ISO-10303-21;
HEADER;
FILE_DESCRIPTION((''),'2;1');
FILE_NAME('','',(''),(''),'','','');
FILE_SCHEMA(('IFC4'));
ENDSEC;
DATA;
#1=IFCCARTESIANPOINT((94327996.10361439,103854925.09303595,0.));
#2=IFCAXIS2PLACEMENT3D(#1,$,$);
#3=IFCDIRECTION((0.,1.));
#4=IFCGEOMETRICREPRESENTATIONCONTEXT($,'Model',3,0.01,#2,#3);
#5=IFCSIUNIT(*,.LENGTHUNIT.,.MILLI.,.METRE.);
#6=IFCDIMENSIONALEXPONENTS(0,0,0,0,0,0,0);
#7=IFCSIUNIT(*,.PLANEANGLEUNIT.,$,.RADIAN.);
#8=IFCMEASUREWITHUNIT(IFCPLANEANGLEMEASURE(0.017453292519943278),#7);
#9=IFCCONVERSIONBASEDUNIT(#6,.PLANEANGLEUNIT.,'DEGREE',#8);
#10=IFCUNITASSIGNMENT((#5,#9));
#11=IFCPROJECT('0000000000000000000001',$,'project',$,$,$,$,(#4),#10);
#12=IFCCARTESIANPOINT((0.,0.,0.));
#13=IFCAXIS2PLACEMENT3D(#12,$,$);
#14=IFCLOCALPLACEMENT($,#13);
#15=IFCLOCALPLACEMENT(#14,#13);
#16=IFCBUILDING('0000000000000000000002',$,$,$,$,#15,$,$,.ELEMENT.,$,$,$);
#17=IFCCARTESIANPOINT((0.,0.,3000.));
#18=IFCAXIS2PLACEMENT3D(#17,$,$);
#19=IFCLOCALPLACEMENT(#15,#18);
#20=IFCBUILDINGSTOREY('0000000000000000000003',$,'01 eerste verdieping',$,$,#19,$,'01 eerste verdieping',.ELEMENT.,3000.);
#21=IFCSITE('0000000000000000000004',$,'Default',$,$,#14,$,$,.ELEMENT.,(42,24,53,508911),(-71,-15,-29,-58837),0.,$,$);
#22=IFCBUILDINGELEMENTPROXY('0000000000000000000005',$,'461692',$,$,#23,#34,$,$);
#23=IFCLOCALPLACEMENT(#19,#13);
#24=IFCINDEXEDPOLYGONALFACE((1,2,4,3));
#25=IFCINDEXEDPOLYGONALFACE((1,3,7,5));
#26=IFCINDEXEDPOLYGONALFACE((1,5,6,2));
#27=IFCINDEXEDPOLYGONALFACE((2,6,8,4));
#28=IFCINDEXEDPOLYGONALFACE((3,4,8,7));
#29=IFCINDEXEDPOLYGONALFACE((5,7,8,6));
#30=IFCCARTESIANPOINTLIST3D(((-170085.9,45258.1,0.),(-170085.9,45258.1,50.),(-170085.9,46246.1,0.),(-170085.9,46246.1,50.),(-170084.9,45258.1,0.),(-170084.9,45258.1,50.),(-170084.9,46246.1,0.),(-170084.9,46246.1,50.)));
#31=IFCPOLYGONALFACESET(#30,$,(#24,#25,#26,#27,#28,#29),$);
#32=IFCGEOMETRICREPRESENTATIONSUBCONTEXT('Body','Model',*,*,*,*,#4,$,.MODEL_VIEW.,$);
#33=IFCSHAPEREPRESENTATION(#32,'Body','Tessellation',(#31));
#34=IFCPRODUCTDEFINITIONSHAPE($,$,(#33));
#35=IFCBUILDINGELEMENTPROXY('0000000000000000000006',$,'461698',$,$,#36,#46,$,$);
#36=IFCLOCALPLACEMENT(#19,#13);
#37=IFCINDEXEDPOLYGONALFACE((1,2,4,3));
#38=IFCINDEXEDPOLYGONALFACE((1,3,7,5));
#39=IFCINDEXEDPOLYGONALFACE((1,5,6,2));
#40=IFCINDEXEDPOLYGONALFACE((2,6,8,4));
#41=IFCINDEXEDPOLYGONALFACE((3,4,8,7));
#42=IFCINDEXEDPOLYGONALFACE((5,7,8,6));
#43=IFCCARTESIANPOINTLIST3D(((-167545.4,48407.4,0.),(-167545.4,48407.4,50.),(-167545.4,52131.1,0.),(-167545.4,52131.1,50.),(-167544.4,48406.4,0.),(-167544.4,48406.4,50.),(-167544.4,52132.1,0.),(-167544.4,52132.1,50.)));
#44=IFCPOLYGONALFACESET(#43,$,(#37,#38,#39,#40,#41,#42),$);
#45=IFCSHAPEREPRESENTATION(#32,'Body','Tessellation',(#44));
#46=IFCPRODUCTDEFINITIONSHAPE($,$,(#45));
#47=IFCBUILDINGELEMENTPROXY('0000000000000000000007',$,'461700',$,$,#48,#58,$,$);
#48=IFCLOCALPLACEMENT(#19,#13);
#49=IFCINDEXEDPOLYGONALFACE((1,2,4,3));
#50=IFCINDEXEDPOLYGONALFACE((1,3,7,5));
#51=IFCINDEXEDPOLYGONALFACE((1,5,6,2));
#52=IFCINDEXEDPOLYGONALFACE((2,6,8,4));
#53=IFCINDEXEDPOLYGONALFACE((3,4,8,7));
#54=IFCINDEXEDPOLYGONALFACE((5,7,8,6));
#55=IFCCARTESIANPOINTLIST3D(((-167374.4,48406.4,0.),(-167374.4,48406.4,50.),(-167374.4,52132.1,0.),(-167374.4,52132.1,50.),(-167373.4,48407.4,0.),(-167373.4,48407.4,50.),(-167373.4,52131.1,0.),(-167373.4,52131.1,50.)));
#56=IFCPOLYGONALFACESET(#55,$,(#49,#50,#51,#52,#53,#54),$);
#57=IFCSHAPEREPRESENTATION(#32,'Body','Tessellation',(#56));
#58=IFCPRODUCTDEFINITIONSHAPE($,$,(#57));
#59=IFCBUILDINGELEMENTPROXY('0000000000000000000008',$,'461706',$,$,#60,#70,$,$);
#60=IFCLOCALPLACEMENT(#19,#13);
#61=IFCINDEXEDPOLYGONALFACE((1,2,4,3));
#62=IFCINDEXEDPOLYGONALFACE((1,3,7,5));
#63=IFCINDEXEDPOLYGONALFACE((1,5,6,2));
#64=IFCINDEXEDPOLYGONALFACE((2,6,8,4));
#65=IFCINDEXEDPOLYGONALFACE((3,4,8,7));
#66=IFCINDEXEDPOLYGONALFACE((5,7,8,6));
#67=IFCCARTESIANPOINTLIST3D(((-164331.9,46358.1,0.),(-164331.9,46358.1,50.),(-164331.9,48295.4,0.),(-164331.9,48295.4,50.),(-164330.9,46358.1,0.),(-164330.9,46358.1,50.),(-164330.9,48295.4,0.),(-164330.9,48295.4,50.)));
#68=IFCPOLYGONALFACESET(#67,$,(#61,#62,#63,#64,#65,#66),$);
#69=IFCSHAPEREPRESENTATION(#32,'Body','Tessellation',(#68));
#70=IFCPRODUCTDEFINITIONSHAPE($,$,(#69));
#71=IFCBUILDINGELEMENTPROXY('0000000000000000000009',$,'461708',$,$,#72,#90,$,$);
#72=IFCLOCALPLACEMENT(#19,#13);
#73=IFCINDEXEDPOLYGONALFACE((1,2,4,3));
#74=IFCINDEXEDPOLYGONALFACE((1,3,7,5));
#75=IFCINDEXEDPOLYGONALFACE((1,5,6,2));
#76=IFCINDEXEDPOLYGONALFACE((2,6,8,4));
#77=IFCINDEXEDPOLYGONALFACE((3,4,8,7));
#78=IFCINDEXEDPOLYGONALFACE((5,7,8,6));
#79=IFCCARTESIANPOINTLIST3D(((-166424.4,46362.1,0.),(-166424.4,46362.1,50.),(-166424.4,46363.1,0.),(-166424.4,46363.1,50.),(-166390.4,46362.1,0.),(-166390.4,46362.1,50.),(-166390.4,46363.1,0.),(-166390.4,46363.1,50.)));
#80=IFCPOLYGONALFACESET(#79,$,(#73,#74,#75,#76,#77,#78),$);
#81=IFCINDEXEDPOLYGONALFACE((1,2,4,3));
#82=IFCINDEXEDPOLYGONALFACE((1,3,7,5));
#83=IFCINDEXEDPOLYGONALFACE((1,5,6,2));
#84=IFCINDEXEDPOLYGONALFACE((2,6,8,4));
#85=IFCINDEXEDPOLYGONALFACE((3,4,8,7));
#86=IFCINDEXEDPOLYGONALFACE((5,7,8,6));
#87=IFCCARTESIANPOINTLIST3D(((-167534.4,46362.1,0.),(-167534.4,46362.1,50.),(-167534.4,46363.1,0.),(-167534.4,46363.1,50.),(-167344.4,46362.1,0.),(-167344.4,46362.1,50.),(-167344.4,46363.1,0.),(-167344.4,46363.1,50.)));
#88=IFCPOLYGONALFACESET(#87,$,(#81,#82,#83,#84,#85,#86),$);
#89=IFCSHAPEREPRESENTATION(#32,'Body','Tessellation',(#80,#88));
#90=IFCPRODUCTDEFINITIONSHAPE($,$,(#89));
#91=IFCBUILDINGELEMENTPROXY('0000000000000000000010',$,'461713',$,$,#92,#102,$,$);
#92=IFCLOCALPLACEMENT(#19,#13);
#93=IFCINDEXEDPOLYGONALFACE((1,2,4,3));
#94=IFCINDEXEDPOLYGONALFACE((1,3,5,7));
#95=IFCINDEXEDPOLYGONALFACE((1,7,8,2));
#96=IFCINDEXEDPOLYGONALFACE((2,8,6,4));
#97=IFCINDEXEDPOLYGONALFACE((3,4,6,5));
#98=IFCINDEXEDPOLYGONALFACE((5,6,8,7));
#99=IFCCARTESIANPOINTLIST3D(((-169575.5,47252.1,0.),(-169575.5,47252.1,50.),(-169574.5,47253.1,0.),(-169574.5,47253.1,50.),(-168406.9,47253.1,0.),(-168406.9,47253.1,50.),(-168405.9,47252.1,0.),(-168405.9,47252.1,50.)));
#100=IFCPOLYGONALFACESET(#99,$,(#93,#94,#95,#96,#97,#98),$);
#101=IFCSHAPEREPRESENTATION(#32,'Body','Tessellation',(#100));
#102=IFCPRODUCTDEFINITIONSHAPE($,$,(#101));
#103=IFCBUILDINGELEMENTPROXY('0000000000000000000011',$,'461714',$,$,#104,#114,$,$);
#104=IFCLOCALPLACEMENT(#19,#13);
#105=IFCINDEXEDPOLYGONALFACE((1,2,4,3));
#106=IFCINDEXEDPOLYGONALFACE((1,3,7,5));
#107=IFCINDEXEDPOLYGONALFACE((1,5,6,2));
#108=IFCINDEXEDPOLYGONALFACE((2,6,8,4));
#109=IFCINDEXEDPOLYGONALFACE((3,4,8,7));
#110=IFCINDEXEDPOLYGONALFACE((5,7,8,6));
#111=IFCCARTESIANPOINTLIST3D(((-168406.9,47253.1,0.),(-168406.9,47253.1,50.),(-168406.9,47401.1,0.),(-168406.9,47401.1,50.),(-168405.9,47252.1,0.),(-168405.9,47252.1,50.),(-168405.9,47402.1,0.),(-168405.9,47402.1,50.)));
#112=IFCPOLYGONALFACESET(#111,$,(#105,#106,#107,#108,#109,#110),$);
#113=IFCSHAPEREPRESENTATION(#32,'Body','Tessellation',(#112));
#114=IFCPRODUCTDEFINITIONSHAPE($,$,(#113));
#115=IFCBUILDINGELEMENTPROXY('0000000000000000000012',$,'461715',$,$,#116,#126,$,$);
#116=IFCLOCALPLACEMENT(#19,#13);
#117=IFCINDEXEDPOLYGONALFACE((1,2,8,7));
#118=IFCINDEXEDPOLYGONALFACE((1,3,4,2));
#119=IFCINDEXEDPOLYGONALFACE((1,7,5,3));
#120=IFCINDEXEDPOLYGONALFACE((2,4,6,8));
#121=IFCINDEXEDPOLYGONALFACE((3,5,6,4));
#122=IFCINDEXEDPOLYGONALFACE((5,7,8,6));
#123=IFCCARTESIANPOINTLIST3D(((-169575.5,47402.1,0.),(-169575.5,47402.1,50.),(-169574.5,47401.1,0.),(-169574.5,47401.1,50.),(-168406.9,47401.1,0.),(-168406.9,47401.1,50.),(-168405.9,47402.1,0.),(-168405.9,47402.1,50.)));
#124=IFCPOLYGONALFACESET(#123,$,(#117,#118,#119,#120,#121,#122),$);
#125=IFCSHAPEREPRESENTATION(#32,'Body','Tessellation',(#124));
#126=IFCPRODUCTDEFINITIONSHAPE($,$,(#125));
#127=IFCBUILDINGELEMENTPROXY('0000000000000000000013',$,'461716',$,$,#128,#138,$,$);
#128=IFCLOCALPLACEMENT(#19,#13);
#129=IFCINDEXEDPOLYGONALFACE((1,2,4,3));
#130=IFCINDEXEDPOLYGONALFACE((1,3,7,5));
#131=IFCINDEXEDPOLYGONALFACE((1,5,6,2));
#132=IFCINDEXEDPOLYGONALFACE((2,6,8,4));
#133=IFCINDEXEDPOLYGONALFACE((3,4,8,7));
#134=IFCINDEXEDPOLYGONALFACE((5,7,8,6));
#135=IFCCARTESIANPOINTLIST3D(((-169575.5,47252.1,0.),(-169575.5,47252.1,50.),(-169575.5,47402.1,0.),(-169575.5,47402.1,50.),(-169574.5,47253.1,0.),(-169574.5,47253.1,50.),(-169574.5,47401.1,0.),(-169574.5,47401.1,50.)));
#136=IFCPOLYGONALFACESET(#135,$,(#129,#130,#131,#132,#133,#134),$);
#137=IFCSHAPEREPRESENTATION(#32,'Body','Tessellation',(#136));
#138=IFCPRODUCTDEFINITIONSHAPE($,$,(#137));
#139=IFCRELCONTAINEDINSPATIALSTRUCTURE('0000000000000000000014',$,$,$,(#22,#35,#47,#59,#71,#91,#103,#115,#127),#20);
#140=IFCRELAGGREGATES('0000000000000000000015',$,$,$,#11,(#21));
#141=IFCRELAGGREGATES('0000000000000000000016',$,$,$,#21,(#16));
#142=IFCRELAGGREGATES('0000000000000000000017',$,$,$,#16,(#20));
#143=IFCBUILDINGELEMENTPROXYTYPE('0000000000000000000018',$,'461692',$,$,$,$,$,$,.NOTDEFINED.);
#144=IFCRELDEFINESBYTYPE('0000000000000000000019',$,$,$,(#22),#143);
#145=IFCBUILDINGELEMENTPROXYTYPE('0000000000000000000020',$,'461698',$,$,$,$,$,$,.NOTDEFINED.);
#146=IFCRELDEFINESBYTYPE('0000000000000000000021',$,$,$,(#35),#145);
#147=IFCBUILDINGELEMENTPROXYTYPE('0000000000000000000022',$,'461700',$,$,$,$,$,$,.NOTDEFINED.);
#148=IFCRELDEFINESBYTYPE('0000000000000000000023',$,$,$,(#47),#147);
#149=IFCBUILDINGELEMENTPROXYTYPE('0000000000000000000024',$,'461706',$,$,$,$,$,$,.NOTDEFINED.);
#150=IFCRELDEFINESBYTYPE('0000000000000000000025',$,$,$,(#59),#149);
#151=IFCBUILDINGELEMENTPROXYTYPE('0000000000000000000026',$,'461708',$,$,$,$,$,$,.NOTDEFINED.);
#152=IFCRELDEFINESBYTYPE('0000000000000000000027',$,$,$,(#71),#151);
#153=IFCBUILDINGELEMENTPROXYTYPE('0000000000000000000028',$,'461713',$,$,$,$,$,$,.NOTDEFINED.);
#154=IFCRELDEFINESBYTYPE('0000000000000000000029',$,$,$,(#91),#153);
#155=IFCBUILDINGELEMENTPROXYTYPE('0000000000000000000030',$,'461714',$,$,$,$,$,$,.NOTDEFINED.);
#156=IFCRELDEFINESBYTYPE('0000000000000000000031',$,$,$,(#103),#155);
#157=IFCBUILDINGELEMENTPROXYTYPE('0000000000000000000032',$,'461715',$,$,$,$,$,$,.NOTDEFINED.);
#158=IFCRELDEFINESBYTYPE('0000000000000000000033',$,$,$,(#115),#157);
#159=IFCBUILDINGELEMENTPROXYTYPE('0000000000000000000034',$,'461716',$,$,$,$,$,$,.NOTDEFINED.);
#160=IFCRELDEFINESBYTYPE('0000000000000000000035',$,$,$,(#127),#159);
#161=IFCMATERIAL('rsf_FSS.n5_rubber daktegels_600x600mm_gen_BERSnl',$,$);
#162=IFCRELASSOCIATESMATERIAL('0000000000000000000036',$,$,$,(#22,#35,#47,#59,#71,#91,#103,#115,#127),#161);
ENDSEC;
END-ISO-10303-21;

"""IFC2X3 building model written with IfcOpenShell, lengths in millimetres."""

from ifc_helpers import new_model, entity, si_unit, converted_unit, direction, frame, frame_2d, origin, origin_2d_with_axis, place, context, subcontext, project, spatial, polyline, rectangle, outline, extrude, material, type_object, element, save


model = new_model("IFC2X3")

# Units and contexts
model_context = context("Model", 3, precision=0.01, world=frame((94327996.10361439, 103854925.09303595, 0.0)), true_north=direction((0.0, 1.0)))
body_context = subcontext(model_context, "Body", "Model", "MODEL_VIEW")
ifc_project = project(units=[si_unit("LENGTHUNIT", "METRE", prefix="MILLI"), converted_unit("PLANEANGLEUNIT", "DEGREE", entity("IfcPlaneAngleMeasure", 0.017453292519943278), si_unit("PLANEANGLEUNIT", "RADIAN"), dimensions=[0, 0, 0, 0, 0, 0, 0])], contexts=[model_context])

# Site, building, storey
site_placement = place(None, origin())
site = spatial("IfcSite", under=ifc_project, at=site_placement, Name="Default", CompositionType="ELEMENT", RefLatitude=(42, 24, 53, 508911), RefLongitude=(-71, -15, -29, -58837), RefElevation=0.0)
building_placement = place(site_placement, origin())
building = spatial("IfcBuilding", under=site, at=building_placement, CompositionType="ELEMENT")
storey_placement = place(building_placement, frame((0.0, 0.0, 3000.0)))
storey = spatial("IfcBuildingStorey", under=building, at=storey_placement, Name="01 eerste verdieping", LongName="01 eerste verdieping", CompositionType="ELEMENT", Elevation=3000.0)

# Building element proxies
ifc_material_1 = material(Name="rsf_FSS.n5_rubber daktegels_600x600mm_gen_BERSnl")
building_element_proxy_type_1 = type_object("IfcBuildingElementProxyType", Name="461692", PredefinedType="NOTDEFINED")
proxy_1_placement = place(storey_placement, origin())
element("IfcBuildingElementProxy", 1, at=proxy_1_placement, inside=storey, type_object=building_element_proxy_type_1, material=ifc_material_1, Name="461692", context=body_context, shape_type="SweptSolid", body=[
    extrude(rectangle(XDim=988.0, YDim=1.0, at=frame_2d((0.0, 0.0), x_axis=(1.0, 0.0))), frame((-170085.4, 45752.1, 0.0), z_axis=(0.0, 0.0, 1.0), x_axis=(0.0, 1.0, 0.0)), (0.0, 0.0, 1.0), 50.0),
])
building_element_proxy_type_2 = type_object("IfcBuildingElementProxyType", Name="461698", PredefinedType="NOTDEFINED")
proxy_2_placement = place(storey_placement, origin())
element("IfcBuildingElementProxy", 2, at=proxy_2_placement, inside=storey, type_object=building_element_proxy_type_2, material=ifc_material_1, Name="461698", context=body_context, shape_type="SweptSolid", body=[
    extrude(outline(polyline([(-1861.8, -0.5), (1861.8, -0.5), (1862.8, 0.5), (-1862.8, 0.5), (-1861.8, -0.5)])), frame((-167544.9, 50269.2, 0.0), z_axis=(0.0, 0.0, 1.0), x_axis=(0.0, -1.0, 0.0)), (0.0, 0.0, 1.0), 50.0),
])
building_element_proxy_type_3 = type_object("IfcBuildingElementProxyType", Name="461700", PredefinedType="NOTDEFINED")
proxy_3_placement = place(storey_placement, origin())
element("IfcBuildingElementProxy", 3, at=proxy_3_placement, inside=storey, type_object=building_element_proxy_type_3, material=ifc_material_1, Name="461700", context=body_context, shape_type="SweptSolid", body=[
    extrude(outline(polyline([(-1861.8, -0.5), (1861.8, -0.5), (1862.8, 0.5), (-1862.8, 0.5), (-1861.8, -0.5)])), frame((-167373.9, 50269.2, 0.0), z_axis=(0.0, 0.0, 1.0), x_axis=(0.0, 1.0, 0.0)), (0.0, 0.0, 1.0), 50.0),
])
building_element_proxy_type_4 = type_object("IfcBuildingElementProxyType", Name="461706", PredefinedType="NOTDEFINED")
proxy_4_placement = place(storey_placement, origin())
element("IfcBuildingElementProxy", 4, at=proxy_4_placement, inside=storey, type_object=building_element_proxy_type_4, material=ifc_material_1, Name="461706", context=body_context, shape_type="SweptSolid", body=[
    extrude(rectangle(XDim=1937.4, YDim=1.0, at=frame_2d((0.0, 0.0), x_axis=(1.0, 0.0))), frame((-164331.4, 47326.7, 0.0), z_axis=(0.0, 0.0, 1.0), x_axis=(0.0, -1.0, 0.0)), (0.0, 0.0, 1.0), 50.0),
])
building_element_proxy_type_5 = type_object("IfcBuildingElementProxyType", Name="461708", PredefinedType="NOTDEFINED")
proxy_5_placement = place(storey_placement, origin())
element("IfcBuildingElementProxy", 5, at=proxy_5_placement, inside=storey, type_object=building_element_proxy_type_5, material=ifc_material_1, Name="461708", context=body_context, shape_type="SweptSolid", body=[
    extrude(rectangle(XDim=34.0, YDim=1.0, at=origin_2d_with_axis()), frame((-166407.4, 46362.6, 0.0), z_axis=(0.0, 0.0, 1.0), x_axis=(-1.0, 0.0, 0.0)), (0.0, 0.0, 1.0), 50.0),
    extrude(rectangle(XDim=190.0, YDim=1.0, at=frame_2d((0.0, 0.0), x_axis=(1.0, 0.0))), frame((-167439.4, 46362.6, 0.0), z_axis=(0.0, 0.0, 1.0), x_axis=(-1.0, 0.0, 0.0)), (0.0, 0.0, 1.0), 50.0),
])
building_element_proxy_type_6 = type_object("IfcBuildingElementProxyType", Name="461713", PredefinedType="NOTDEFINED")
proxy_6_placement = place(storey_placement, origin())
element("IfcBuildingElementProxy", 6, at=proxy_6_placement, inside=storey, type_object=building_element_proxy_type_6, material=ifc_material_1, Name="461713", context=body_context, shape_type="SweptSolid", body=[
    extrude(outline(polyline([(-583.8, -0.5), (583.8, -0.5), (584.8, 0.5), (-584.8, 0.5), (-583.8, -0.5)])), frame((-168990.7, 47252.6, 0.0), z_axis=(0.0, 0.0, 1.0), x_axis=(-1.0, 0.0, 0.0)), (0.0, 0.0, 1.0), 50.0),
])
building_element_proxy_type_7 = type_object("IfcBuildingElementProxyType", Name="461714", PredefinedType="NOTDEFINED")
proxy_7_placement = place(storey_placement, origin())
element("IfcBuildingElementProxy", 7, at=proxy_7_placement, inside=storey, type_object=building_element_proxy_type_7, material=ifc_material_1, Name="461714", context=body_context, shape_type="SweptSolid", body=[
    extrude(outline(polyline([(-74.0, -0.5), (74.0, -0.5), (75.0, 0.5), (-75.0, 0.5), (-74.0, -0.5)])), frame((-168406.4, 47327.1, 0.0), z_axis=(0.0, 0.0, 1.0), x_axis=(0.0, -1.0, 0.0)), (0.0, 0.0, 1.0), 50.0),
])
building_element_proxy_type_8 = type_object("IfcBuildingElementProxyType", Name="461715", PredefinedType="NOTDEFINED")
proxy_8_placement = place(storey_placement, origin())
element("IfcBuildingElementProxy", 8, at=proxy_8_placement, inside=storey, type_object=building_element_proxy_type_8, material=ifc_material_1, Name="461715", context=body_context, shape_type="SweptSolid", body=[
    extrude(outline(polyline([(-583.8, -0.5), (583.8, -0.5), (584.8, 0.5), (-584.8, 0.5), (-583.8, -0.5)])), frame((-168990.7, 47401.6, 0.0)), (0.0, 0.0, 1.0), 50.0),
])
building_element_proxy_type_9 = type_object("IfcBuildingElementProxyType", Name="461716", PredefinedType="NOTDEFINED")
proxy_9_placement = place(storey_placement, origin())
element("IfcBuildingElementProxy", 9, at=proxy_9_placement, inside=storey, type_object=building_element_proxy_type_9, material=ifc_material_1, Name="461716", context=body_context, shape_type="SweptSolid", body=[
    extrude(outline(polyline([(-74.0, -0.5), (74.0, -0.5), (75.0, 0.5), (-75.0, 0.5), (-74.0, -0.5)])), frame((-169575.0, 47327.1, 0.0), z_axis=(0.0, 0.0, 1.0), x_axis=(0.0, 1.0, 0.0)), (0.0, 0.0, 1.0), 50.0),
])

save(model, "model.ifc")
